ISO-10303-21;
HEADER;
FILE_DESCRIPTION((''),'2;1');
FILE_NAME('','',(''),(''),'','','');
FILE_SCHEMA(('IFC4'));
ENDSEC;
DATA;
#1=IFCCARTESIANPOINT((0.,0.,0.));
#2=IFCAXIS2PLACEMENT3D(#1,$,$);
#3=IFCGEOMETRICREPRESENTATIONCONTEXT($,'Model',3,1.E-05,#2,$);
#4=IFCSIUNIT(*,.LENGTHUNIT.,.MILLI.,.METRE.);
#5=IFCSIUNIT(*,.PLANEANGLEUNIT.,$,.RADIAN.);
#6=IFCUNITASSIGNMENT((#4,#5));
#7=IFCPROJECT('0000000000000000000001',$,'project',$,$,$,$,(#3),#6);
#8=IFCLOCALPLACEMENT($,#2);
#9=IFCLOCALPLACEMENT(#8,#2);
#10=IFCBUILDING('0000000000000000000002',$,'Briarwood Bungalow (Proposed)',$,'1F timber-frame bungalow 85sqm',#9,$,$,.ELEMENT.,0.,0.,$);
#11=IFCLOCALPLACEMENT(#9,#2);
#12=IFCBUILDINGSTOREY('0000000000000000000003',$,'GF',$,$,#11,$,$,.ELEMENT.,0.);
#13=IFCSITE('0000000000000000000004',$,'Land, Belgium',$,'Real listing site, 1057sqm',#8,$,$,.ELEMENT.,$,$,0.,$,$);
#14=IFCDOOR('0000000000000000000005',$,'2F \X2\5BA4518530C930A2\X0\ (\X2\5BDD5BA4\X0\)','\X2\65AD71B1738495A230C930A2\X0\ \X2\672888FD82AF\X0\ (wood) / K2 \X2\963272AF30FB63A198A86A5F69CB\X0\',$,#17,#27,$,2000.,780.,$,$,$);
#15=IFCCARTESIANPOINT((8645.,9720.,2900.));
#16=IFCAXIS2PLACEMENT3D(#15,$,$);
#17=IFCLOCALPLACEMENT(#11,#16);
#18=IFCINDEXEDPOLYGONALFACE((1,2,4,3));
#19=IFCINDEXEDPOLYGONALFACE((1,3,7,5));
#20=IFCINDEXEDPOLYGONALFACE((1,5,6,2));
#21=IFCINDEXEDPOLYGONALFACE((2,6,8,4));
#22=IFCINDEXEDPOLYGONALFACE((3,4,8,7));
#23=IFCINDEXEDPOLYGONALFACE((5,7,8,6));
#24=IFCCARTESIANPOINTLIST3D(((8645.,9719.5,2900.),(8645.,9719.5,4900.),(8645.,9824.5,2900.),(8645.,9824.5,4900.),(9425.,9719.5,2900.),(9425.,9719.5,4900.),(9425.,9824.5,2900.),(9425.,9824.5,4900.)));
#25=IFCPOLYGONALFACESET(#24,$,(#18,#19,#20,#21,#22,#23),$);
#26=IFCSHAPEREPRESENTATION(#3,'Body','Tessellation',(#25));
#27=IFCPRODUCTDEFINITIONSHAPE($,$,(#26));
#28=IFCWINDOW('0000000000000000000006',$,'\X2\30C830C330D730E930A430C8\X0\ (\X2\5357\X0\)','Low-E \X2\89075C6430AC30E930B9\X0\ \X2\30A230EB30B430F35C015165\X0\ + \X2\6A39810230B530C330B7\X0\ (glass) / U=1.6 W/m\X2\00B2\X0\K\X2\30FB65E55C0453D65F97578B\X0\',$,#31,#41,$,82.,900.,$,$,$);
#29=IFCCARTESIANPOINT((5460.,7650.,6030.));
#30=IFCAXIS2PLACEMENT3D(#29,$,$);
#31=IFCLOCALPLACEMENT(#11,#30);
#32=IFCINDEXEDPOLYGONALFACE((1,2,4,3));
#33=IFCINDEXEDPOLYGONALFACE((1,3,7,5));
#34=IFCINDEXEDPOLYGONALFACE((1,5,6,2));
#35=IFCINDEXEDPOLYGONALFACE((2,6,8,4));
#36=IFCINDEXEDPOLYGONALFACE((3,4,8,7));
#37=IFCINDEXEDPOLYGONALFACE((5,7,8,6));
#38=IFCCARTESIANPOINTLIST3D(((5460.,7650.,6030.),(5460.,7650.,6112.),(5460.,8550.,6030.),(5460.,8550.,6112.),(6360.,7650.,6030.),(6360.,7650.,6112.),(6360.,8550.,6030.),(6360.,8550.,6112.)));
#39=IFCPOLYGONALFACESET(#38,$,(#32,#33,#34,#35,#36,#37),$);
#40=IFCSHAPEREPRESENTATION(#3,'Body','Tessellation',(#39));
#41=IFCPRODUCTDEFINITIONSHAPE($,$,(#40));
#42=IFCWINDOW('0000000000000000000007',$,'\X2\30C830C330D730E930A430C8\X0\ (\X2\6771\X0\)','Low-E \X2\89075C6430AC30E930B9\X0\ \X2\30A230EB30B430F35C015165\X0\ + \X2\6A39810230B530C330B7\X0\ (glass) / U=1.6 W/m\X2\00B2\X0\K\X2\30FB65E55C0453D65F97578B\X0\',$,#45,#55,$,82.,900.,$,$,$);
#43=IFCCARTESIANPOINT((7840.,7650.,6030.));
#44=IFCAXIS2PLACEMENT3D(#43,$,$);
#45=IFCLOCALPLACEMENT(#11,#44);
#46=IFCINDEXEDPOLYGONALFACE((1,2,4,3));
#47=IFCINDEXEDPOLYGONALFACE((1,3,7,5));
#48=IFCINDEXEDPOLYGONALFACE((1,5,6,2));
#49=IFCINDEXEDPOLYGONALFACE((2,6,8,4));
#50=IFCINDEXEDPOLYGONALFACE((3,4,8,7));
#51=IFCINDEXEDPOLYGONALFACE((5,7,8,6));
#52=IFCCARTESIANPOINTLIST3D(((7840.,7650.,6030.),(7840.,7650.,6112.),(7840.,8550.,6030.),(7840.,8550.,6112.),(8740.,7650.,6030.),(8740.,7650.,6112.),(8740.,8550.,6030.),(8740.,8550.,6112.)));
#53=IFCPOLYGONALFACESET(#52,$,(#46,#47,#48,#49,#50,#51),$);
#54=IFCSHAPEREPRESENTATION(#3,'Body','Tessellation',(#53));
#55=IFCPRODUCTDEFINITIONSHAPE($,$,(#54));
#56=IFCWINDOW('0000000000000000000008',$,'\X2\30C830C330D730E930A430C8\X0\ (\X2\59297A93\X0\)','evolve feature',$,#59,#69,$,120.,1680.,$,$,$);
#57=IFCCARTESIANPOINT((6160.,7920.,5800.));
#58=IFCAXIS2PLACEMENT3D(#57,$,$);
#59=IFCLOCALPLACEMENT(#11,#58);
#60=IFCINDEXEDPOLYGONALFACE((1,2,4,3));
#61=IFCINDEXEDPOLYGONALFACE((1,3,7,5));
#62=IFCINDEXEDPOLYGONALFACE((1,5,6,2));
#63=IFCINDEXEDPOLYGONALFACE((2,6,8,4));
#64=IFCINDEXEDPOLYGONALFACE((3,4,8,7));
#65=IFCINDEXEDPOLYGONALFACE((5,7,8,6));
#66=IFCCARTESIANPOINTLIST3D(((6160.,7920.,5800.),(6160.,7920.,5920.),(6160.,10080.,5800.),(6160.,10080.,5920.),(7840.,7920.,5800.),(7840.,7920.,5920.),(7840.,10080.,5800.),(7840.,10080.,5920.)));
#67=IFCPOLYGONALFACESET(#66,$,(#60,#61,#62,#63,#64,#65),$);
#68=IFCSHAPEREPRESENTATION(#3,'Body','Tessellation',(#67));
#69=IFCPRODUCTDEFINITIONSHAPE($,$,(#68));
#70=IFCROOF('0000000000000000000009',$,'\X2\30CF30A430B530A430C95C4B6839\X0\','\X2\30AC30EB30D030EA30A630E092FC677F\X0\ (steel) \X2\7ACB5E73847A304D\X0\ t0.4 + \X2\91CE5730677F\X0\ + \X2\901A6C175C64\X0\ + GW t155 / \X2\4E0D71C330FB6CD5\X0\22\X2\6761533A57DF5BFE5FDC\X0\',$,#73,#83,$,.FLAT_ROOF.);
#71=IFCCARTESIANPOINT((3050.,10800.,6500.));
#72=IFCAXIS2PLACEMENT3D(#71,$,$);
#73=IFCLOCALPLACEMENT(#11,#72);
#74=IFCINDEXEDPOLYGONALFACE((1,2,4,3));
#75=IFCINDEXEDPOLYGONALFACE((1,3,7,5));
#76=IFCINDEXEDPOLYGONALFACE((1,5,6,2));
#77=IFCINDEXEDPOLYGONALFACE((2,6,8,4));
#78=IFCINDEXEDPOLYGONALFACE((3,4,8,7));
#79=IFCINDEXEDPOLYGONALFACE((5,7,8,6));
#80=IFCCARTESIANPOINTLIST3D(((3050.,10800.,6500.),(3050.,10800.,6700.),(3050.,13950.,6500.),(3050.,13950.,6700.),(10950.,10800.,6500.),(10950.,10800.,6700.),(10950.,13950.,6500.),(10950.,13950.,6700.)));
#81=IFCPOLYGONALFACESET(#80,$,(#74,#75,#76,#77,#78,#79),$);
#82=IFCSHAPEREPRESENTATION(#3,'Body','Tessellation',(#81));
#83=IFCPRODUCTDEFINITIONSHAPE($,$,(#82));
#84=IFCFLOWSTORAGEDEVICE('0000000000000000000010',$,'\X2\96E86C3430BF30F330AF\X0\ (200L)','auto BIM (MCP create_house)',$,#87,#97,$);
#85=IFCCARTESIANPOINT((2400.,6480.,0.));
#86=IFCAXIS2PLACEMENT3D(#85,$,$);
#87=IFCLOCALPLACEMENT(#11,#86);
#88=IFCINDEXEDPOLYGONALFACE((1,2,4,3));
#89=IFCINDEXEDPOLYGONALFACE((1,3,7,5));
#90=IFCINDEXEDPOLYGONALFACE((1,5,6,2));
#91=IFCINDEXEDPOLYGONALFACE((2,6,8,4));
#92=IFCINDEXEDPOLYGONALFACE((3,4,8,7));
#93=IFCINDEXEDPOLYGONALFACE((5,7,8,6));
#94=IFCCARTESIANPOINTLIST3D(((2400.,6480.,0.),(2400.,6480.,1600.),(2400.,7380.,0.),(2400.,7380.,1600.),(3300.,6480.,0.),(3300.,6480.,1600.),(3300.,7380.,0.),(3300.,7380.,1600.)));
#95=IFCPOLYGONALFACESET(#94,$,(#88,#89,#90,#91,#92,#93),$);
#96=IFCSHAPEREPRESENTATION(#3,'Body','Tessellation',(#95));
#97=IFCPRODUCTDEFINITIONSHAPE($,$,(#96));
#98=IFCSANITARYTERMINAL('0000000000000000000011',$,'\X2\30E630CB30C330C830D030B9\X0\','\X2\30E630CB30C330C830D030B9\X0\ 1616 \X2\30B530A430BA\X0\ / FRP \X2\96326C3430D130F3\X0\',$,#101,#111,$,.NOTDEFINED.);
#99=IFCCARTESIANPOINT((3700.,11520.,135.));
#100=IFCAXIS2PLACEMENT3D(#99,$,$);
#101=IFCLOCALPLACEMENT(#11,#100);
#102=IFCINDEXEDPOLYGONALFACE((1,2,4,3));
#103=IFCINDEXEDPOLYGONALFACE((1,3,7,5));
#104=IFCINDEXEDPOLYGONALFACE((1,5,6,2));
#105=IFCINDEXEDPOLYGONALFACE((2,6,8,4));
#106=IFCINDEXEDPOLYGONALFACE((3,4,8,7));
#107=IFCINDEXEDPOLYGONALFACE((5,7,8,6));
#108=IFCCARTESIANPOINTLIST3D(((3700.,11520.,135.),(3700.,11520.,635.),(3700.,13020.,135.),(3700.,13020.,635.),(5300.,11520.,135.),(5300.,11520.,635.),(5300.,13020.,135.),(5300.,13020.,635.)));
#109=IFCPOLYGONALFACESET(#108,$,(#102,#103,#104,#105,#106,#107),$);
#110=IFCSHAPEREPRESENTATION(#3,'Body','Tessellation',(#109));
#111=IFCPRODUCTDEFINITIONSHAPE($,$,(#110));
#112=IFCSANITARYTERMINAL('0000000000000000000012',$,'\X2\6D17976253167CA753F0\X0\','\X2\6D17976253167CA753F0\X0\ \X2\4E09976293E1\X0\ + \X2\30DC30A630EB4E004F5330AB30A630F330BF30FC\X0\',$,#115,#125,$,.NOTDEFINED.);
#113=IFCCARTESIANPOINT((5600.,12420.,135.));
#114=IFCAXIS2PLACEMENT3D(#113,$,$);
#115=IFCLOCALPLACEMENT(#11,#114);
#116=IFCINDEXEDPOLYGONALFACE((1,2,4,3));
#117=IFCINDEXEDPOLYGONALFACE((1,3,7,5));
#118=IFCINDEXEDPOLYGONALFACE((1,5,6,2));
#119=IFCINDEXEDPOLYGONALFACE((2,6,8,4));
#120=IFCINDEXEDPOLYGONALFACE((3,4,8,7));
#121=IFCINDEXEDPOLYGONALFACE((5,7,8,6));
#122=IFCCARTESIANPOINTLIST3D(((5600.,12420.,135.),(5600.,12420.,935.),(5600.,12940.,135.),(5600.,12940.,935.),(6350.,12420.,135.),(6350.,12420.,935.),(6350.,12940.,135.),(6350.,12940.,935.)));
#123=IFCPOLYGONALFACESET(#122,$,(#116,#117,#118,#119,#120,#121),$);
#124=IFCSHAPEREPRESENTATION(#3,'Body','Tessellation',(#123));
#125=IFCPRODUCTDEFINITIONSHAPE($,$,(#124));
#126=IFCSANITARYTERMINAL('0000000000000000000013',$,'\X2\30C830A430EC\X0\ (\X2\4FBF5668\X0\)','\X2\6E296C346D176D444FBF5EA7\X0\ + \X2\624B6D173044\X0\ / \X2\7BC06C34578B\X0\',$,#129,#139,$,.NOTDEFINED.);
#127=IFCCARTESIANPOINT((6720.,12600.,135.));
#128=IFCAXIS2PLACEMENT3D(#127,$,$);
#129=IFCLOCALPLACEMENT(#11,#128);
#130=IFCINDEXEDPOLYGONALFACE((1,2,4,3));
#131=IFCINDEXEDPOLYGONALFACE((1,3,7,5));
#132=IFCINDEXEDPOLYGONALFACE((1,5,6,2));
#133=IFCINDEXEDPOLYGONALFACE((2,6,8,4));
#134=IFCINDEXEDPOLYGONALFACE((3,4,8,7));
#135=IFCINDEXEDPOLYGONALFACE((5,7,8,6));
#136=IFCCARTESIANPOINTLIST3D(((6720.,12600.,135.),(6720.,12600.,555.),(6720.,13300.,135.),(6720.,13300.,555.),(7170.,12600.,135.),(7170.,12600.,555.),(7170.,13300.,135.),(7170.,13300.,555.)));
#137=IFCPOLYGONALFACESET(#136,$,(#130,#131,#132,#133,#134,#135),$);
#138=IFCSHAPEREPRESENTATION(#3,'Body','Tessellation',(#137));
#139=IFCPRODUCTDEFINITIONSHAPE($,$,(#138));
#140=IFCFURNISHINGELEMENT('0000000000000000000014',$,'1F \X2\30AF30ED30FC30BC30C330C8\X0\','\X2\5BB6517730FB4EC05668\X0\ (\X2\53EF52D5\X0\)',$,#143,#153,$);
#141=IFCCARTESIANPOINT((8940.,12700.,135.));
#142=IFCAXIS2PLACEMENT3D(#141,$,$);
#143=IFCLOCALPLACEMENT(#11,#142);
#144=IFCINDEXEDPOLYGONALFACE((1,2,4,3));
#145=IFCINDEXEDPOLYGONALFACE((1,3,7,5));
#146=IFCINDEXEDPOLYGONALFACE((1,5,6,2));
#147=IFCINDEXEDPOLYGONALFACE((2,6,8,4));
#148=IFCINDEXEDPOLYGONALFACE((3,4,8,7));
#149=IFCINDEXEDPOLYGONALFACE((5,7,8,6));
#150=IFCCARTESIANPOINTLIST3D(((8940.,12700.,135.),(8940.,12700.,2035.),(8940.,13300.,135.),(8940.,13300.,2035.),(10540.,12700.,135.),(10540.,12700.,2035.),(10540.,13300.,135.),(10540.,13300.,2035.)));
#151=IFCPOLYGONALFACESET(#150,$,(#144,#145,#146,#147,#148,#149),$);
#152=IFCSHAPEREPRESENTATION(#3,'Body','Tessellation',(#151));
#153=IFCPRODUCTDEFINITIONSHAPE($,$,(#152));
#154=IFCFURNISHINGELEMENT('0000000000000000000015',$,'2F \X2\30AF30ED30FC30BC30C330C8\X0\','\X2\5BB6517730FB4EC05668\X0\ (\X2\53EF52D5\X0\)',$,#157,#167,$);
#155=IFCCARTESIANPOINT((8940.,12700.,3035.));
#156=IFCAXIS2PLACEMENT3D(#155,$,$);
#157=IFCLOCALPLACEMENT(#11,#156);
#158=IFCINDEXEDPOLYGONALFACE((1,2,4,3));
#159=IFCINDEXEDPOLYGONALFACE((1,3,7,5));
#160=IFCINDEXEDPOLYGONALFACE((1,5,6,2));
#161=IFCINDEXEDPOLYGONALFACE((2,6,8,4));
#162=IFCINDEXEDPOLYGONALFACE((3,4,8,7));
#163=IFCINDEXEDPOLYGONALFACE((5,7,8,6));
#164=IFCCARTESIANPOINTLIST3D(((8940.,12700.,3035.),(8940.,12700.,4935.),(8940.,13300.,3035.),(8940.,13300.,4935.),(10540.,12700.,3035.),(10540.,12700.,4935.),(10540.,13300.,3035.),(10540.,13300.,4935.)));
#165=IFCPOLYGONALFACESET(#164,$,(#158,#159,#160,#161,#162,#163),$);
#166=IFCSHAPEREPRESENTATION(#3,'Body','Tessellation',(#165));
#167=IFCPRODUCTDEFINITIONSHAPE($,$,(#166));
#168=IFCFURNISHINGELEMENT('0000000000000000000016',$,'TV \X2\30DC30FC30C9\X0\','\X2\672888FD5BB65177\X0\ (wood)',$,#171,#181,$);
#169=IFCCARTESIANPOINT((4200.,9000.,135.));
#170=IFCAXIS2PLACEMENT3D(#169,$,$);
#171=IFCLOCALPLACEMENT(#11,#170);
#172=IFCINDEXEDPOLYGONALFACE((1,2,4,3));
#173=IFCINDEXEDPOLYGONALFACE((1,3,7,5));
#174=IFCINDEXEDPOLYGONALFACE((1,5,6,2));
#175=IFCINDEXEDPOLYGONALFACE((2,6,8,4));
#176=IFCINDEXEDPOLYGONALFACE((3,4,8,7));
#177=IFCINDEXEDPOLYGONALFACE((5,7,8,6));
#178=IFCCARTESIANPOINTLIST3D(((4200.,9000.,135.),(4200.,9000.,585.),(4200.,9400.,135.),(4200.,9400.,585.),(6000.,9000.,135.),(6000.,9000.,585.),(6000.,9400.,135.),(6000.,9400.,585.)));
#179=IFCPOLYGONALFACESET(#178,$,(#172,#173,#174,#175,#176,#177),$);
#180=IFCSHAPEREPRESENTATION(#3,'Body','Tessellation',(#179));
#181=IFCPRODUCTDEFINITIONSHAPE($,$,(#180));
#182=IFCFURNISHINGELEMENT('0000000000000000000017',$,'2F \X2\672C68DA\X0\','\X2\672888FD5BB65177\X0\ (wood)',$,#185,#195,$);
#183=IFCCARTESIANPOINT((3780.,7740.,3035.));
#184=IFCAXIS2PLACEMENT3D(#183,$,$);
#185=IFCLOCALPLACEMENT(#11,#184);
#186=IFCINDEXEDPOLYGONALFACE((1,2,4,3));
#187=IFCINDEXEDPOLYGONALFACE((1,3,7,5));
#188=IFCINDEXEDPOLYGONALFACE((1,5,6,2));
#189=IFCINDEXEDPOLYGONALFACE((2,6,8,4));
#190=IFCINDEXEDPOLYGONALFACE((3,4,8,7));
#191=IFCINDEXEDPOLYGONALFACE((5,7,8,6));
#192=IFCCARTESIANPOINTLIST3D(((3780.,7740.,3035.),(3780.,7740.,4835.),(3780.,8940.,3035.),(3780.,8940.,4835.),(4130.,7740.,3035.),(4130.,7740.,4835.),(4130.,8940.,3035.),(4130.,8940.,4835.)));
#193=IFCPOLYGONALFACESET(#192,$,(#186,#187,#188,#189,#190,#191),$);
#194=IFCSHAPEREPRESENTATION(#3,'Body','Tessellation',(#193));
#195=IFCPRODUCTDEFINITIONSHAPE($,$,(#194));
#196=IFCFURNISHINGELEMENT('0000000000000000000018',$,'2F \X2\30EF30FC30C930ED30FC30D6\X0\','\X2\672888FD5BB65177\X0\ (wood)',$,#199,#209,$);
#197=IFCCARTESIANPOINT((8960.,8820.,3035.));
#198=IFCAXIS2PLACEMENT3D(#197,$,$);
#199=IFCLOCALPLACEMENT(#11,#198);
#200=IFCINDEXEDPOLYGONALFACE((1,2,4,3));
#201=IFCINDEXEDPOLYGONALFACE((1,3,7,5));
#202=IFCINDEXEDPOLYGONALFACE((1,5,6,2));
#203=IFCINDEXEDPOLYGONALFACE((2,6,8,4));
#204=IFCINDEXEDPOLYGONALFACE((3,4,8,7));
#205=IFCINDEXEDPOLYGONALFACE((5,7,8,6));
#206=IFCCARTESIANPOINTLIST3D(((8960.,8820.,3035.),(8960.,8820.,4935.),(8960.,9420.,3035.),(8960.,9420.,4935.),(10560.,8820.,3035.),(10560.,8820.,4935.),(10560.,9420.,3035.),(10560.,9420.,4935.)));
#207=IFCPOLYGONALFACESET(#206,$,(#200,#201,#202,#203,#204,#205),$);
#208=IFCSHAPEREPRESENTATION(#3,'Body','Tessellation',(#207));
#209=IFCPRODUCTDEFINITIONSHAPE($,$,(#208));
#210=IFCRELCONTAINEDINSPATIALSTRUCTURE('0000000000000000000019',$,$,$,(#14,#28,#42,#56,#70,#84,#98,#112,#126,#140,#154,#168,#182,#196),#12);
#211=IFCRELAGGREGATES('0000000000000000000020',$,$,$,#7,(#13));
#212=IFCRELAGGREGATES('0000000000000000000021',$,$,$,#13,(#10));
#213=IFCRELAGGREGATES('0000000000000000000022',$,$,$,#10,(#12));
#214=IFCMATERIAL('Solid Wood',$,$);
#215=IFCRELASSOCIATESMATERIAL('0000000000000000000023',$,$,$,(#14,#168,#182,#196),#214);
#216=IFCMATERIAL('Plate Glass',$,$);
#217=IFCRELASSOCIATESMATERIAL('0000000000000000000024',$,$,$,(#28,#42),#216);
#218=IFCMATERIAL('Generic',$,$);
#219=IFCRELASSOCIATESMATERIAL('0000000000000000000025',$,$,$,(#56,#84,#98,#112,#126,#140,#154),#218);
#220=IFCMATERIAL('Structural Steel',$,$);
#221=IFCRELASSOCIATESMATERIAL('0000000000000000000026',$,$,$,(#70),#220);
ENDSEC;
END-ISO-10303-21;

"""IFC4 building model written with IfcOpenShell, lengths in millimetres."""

from ifc_helpers import new_model, si_unit, frame, frame_2d, origin, place, context, project, spatial, rectangle, extrude, material, element, save


model = new_model("IFC4")

# Units and contexts
model_context = context("Model", 3, precision=1e-05, world=origin())
ifc_project = project(units=[si_unit("LENGTHUNIT", "METRE", prefix="MILLI"), si_unit("PLANEANGLEUNIT", "RADIAN")], contexts=[model_context])

# Site, building, storey
site_placement = place(None, origin())
site = spatial("IfcSite", under=ifc_project, at=site_placement, Name="Land, Belgium", ObjectType="Real listing site, 1057sqm", CompositionType="ELEMENT", RefElevation=0.0)
building_placement = place(site_placement, origin())
building = spatial("IfcBuilding", under=site, at=building_placement, Name="Briarwood Bungalow (Proposed)", ObjectType="1F timber-frame bungalow 85sqm", CompositionType="ELEMENT", ElevationOfRefHeight=0.0, ElevationOfTerrain=0.0)
storey_placement = place(building_placement, origin())
storey = spatial("IfcBuildingStorey", under=building, at=storey_placement, Name="GF", CompositionType="ELEMENT", Elevation=0.0)

# Shared definitions
ifc_material_1 = material(Name="Solid Wood")
ifc_material_2 = material(Name="Plate Glass")

# Door
door_1_placement = place(storey_placement, frame((8645.0, 9720.0, 2900.0)))
element("IfcDoor", 1, at=door_1_placement, inside=storey, material=ifc_material_1, Name="2F 室内ドア (寝室)", Description="断熱玄関ドア 木製芯 (wood) / K2 防犯・採風機構", OverallHeight=2000.0, OverallWidth=780.0, context=model_context, shape_type="SweptSolid", body=[
    extrude(rectangle(XDim=780.0, YDim=105.0, at=frame_2d((390.0, 52.0))), frame((8645.0, 9720.0, 2900.0)), (0.0, 0.0, 1.0), 2000.0),
])

# Windows
window_1_placement = place(storey_placement, frame((5460.0, 7650.0, 6030.0)))
element("IfcWindow", 2, at=window_1_placement, inside=storey, material=ifc_material_2, Name="トップライト (南)", Description="Low-E 複層ガラス アルゴン封入 + 樹脂サッシ (glass) / U=1.6 W/m²K・日射取得型", OverallHeight=82.0, OverallWidth=900.0, context=model_context, shape_type="SweptSolid", body=[
    extrude(rectangle(XDim=900.0, YDim=900.0, at=frame_2d((450.0, 450.0))), frame((5460.0, 7650.0, 6030.0)), (0.0, 0.0, 1.0), 82.0),
])
window_2_placement = place(storey_placement, frame((7840.0, 7650.0, 6030.0)))
element("IfcWindow", 3, at=window_2_placement, inside=storey, material=ifc_material_2, Name="トップライト (東)", Description="Low-E 複層ガラス アルゴン封入 + 樹脂サッシ (glass) / U=1.6 W/m²K・日射取得型", OverallHeight=82.0, OverallWidth=900.0, context=model_context, shape_type="SweptSolid", body=[
    extrude(rectangle(XDim=900.0, YDim=900.0, at=frame_2d((450.0, 450.0))), frame((7840.0, 7650.0, 6030.0)), (0.0, 0.0, 1.0), 82.0),
])
ifc_material_3 = material(Name="Generic")
window_3_placement = place(storey_placement, frame((6160.0, 7920.0, 5800.0)))
element("IfcWindow", 4, at=window_3_placement, inside=storey, material=ifc_material_3, Name="トップライト (天窓)", Description="evolve feature", OverallHeight=120.0, OverallWidth=1680.0, context=model_context, shape_type="SweptSolid", body=[
    extrude(rectangle(XDim=1680.0, YDim=2160.0, at=frame_2d((840.0, 1080.0))), frame((6160.0, 7920.0, 5800.0)), (0.0, 0.0, 1.0), 120.0),
])

# Roof
ifc_material_4 = material(Name="Structural Steel")
roof_placement = place(storey_placement, frame((3050.0, 10800.0, 6500.0)))
element("IfcRoof", 5, at=roof_placement, inside=storey, material=ifc_material_4, Name="ハイサイド屋根", Description="ガルバリウム鋼板 (steel) 立平葺き t0.4 + 野地板 + 通気層 + GW t155 / 不燃・法22条区域対応", PredefinedType="FLAT_ROOF", context=model_context, shape_type="SweptSolid", body=[
    extrude(rectangle(XDim=7900.0, YDim=3150.0, at=frame_2d((3950.0, 1575.0))), frame((3050.0, 10800.0, 6500.0)), (0.0, 0.0, 1.0), 200.0),
])

# Flow storage device
flow_storage_device_placement = place(storey_placement, frame((2400.0, 6480.0, 0.0)))
element("IfcFlowStorageDevice", 6, at=flow_storage_device_placement, inside=storey, material=ifc_material_3, Name="雨水タンク (200L)", Description="auto BIM (MCP create_house)", context=model_context, shape_type="SweptSolid", body=[
    extrude(rectangle(XDim=900.0, YDim=900.0, at=frame_2d((450.0, 450.0))), frame((2400.0, 6480.0, 0.0)), (0.0, 0.0, 1.0), 1600.0),
])

# Sanitary terminals
sanitary_terminal_1_placement = place(storey_placement, frame((3700.0, 11520.0, 135.0)))
element("IfcSanitaryTerminal", 7, at=sanitary_terminal_1_placement, inside=storey, material=ifc_material_3, Name="ユニットバス", Description="ユニットバス 1616 サイズ / FRP 防水パン", PredefinedType="NOTDEFINED", context=model_context, shape_type="SweptSolid", body=[
    extrude(rectangle(XDim=1600.0, YDim=1500.0, at=frame_2d((800.0, 750.0))), frame((3700.0, 11520.0, 135.0)), (0.0, 0.0, 1.0), 500.0),
])
sanitary_terminal_2_placement = place(storey_placement, frame((5600.0, 12420.0, 135.0)))
element("IfcSanitaryTerminal", 8, at=sanitary_terminal_2_placement, inside=storey, material=ifc_material_3, Name="洗面化粧台", Description="洗面化粧台 三面鏡 + ボウル一体カウンター", PredefinedType="NOTDEFINED", context=model_context, shape_type="SweptSolid", body=[
    extrude(rectangle(XDim=750.0, YDim=520.0, at=frame_2d((375.0, 260.0))), frame((5600.0, 12420.0, 135.0)), (0.0, 0.0, 1.0), 800.0),
])
sanitary_terminal_3_placement = place(storey_placement, frame((6720.0, 12600.0, 135.0)))
element("IfcSanitaryTerminal", 9, at=sanitary_terminal_3_placement, inside=storey, material=ifc_material_3, Name="トイレ (便器)", Description="温水洗浄便座 + 手洗い / 節水型", PredefinedType="NOTDEFINED", context=model_context, shape_type="SweptSolid", body=[
    extrude(rectangle(XDim=450.0, YDim=700.0, at=frame_2d((225.0, 350.0))), frame((6720.0, 12600.0, 135.0)), (0.0, 0.0, 1.0), 420.0),
])

# Furnishing elements
furnishing_1_placement = place(storey_placement, frame((8940.0, 12700.0, 135.0)))
element("IfcFurnishingElement", 10, at=furnishing_1_placement, inside=storey, material=ifc_material_3, Name="1F クローゼット", Description="家具・什器 (可動)", context=model_context, shape_type="SweptSolid", body=[
    extrude(rectangle(XDim=1600.0, YDim=600.0, at=frame_2d((800.0, 300.0))), frame((8940.0, 12700.0, 135.0)), (0.0, 0.0, 1.0), 1900.0),
])
furnishing_2_placement = place(storey_placement, frame((8940.0, 12700.0, 3035.0)))
element("IfcFurnishingElement", 11, at=furnishing_2_placement, inside=storey, material=ifc_material_3, Name="2F クローゼット", Description="家具・什器 (可動)", context=model_context, shape_type="SweptSolid", body=[
    extrude(rectangle(XDim=1600.0, YDim=600.0, at=frame_2d((800.0, 300.0))), frame((8940.0, 12700.0, 3035.0)), (0.0, 0.0, 1.0), 1900.0),
])
furnishing_3_placement = place(storey_placement, frame((4200.0, 9000.0, 135.0)))
element("IfcFurnishingElement", 12, at=furnishing_3_placement, inside=storey, material=ifc_material_1, Name="TV ボード", Description="木製家具 (wood)", context=model_context, shape_type="SweptSolid", body=[
    extrude(rectangle(XDim=1800.0, YDim=400.0, at=frame_2d((900.0, 200.0))), frame((4200.0, 9000.0, 135.0)), (0.0, 0.0, 1.0), 450.0),
])
furnishing_4_placement = place(storey_placement, frame((3780.0, 7740.0, 3035.0)))
element("IfcFurnishingElement", 13, at=furnishing_4_placement, inside=storey, material=ifc_material_1, Name="2F 本棚", Description="木製家具 (wood)", context=model_context, shape_type="SweptSolid", body=[
    extrude(rectangle(XDim=350.0, YDim=1200.0, at=frame_2d((175.0, 600.0))), frame((3780.0, 7740.0, 3035.0)), (0.0, 0.0, 1.0), 1800.0),
])
furnishing_5_placement = place(storey_placement, frame((8960.0, 8820.0, 3035.0)))
element("IfcFurnishingElement", 14, at=furnishing_5_placement, inside=storey, material=ifc_material_1, Name="2F ワードローブ", Description="木製家具 (wood)", context=model_context, shape_type="SweptSolid", body=[
    extrude(rectangle(XDim=1600.0, YDim=600.0, at=frame_2d((800.0, 300.0))), frame((8960.0, 8820.0, 3035.0)), (0.0, 0.0, 1.0), 1900.0),
])

save(model, "model.ifc")
